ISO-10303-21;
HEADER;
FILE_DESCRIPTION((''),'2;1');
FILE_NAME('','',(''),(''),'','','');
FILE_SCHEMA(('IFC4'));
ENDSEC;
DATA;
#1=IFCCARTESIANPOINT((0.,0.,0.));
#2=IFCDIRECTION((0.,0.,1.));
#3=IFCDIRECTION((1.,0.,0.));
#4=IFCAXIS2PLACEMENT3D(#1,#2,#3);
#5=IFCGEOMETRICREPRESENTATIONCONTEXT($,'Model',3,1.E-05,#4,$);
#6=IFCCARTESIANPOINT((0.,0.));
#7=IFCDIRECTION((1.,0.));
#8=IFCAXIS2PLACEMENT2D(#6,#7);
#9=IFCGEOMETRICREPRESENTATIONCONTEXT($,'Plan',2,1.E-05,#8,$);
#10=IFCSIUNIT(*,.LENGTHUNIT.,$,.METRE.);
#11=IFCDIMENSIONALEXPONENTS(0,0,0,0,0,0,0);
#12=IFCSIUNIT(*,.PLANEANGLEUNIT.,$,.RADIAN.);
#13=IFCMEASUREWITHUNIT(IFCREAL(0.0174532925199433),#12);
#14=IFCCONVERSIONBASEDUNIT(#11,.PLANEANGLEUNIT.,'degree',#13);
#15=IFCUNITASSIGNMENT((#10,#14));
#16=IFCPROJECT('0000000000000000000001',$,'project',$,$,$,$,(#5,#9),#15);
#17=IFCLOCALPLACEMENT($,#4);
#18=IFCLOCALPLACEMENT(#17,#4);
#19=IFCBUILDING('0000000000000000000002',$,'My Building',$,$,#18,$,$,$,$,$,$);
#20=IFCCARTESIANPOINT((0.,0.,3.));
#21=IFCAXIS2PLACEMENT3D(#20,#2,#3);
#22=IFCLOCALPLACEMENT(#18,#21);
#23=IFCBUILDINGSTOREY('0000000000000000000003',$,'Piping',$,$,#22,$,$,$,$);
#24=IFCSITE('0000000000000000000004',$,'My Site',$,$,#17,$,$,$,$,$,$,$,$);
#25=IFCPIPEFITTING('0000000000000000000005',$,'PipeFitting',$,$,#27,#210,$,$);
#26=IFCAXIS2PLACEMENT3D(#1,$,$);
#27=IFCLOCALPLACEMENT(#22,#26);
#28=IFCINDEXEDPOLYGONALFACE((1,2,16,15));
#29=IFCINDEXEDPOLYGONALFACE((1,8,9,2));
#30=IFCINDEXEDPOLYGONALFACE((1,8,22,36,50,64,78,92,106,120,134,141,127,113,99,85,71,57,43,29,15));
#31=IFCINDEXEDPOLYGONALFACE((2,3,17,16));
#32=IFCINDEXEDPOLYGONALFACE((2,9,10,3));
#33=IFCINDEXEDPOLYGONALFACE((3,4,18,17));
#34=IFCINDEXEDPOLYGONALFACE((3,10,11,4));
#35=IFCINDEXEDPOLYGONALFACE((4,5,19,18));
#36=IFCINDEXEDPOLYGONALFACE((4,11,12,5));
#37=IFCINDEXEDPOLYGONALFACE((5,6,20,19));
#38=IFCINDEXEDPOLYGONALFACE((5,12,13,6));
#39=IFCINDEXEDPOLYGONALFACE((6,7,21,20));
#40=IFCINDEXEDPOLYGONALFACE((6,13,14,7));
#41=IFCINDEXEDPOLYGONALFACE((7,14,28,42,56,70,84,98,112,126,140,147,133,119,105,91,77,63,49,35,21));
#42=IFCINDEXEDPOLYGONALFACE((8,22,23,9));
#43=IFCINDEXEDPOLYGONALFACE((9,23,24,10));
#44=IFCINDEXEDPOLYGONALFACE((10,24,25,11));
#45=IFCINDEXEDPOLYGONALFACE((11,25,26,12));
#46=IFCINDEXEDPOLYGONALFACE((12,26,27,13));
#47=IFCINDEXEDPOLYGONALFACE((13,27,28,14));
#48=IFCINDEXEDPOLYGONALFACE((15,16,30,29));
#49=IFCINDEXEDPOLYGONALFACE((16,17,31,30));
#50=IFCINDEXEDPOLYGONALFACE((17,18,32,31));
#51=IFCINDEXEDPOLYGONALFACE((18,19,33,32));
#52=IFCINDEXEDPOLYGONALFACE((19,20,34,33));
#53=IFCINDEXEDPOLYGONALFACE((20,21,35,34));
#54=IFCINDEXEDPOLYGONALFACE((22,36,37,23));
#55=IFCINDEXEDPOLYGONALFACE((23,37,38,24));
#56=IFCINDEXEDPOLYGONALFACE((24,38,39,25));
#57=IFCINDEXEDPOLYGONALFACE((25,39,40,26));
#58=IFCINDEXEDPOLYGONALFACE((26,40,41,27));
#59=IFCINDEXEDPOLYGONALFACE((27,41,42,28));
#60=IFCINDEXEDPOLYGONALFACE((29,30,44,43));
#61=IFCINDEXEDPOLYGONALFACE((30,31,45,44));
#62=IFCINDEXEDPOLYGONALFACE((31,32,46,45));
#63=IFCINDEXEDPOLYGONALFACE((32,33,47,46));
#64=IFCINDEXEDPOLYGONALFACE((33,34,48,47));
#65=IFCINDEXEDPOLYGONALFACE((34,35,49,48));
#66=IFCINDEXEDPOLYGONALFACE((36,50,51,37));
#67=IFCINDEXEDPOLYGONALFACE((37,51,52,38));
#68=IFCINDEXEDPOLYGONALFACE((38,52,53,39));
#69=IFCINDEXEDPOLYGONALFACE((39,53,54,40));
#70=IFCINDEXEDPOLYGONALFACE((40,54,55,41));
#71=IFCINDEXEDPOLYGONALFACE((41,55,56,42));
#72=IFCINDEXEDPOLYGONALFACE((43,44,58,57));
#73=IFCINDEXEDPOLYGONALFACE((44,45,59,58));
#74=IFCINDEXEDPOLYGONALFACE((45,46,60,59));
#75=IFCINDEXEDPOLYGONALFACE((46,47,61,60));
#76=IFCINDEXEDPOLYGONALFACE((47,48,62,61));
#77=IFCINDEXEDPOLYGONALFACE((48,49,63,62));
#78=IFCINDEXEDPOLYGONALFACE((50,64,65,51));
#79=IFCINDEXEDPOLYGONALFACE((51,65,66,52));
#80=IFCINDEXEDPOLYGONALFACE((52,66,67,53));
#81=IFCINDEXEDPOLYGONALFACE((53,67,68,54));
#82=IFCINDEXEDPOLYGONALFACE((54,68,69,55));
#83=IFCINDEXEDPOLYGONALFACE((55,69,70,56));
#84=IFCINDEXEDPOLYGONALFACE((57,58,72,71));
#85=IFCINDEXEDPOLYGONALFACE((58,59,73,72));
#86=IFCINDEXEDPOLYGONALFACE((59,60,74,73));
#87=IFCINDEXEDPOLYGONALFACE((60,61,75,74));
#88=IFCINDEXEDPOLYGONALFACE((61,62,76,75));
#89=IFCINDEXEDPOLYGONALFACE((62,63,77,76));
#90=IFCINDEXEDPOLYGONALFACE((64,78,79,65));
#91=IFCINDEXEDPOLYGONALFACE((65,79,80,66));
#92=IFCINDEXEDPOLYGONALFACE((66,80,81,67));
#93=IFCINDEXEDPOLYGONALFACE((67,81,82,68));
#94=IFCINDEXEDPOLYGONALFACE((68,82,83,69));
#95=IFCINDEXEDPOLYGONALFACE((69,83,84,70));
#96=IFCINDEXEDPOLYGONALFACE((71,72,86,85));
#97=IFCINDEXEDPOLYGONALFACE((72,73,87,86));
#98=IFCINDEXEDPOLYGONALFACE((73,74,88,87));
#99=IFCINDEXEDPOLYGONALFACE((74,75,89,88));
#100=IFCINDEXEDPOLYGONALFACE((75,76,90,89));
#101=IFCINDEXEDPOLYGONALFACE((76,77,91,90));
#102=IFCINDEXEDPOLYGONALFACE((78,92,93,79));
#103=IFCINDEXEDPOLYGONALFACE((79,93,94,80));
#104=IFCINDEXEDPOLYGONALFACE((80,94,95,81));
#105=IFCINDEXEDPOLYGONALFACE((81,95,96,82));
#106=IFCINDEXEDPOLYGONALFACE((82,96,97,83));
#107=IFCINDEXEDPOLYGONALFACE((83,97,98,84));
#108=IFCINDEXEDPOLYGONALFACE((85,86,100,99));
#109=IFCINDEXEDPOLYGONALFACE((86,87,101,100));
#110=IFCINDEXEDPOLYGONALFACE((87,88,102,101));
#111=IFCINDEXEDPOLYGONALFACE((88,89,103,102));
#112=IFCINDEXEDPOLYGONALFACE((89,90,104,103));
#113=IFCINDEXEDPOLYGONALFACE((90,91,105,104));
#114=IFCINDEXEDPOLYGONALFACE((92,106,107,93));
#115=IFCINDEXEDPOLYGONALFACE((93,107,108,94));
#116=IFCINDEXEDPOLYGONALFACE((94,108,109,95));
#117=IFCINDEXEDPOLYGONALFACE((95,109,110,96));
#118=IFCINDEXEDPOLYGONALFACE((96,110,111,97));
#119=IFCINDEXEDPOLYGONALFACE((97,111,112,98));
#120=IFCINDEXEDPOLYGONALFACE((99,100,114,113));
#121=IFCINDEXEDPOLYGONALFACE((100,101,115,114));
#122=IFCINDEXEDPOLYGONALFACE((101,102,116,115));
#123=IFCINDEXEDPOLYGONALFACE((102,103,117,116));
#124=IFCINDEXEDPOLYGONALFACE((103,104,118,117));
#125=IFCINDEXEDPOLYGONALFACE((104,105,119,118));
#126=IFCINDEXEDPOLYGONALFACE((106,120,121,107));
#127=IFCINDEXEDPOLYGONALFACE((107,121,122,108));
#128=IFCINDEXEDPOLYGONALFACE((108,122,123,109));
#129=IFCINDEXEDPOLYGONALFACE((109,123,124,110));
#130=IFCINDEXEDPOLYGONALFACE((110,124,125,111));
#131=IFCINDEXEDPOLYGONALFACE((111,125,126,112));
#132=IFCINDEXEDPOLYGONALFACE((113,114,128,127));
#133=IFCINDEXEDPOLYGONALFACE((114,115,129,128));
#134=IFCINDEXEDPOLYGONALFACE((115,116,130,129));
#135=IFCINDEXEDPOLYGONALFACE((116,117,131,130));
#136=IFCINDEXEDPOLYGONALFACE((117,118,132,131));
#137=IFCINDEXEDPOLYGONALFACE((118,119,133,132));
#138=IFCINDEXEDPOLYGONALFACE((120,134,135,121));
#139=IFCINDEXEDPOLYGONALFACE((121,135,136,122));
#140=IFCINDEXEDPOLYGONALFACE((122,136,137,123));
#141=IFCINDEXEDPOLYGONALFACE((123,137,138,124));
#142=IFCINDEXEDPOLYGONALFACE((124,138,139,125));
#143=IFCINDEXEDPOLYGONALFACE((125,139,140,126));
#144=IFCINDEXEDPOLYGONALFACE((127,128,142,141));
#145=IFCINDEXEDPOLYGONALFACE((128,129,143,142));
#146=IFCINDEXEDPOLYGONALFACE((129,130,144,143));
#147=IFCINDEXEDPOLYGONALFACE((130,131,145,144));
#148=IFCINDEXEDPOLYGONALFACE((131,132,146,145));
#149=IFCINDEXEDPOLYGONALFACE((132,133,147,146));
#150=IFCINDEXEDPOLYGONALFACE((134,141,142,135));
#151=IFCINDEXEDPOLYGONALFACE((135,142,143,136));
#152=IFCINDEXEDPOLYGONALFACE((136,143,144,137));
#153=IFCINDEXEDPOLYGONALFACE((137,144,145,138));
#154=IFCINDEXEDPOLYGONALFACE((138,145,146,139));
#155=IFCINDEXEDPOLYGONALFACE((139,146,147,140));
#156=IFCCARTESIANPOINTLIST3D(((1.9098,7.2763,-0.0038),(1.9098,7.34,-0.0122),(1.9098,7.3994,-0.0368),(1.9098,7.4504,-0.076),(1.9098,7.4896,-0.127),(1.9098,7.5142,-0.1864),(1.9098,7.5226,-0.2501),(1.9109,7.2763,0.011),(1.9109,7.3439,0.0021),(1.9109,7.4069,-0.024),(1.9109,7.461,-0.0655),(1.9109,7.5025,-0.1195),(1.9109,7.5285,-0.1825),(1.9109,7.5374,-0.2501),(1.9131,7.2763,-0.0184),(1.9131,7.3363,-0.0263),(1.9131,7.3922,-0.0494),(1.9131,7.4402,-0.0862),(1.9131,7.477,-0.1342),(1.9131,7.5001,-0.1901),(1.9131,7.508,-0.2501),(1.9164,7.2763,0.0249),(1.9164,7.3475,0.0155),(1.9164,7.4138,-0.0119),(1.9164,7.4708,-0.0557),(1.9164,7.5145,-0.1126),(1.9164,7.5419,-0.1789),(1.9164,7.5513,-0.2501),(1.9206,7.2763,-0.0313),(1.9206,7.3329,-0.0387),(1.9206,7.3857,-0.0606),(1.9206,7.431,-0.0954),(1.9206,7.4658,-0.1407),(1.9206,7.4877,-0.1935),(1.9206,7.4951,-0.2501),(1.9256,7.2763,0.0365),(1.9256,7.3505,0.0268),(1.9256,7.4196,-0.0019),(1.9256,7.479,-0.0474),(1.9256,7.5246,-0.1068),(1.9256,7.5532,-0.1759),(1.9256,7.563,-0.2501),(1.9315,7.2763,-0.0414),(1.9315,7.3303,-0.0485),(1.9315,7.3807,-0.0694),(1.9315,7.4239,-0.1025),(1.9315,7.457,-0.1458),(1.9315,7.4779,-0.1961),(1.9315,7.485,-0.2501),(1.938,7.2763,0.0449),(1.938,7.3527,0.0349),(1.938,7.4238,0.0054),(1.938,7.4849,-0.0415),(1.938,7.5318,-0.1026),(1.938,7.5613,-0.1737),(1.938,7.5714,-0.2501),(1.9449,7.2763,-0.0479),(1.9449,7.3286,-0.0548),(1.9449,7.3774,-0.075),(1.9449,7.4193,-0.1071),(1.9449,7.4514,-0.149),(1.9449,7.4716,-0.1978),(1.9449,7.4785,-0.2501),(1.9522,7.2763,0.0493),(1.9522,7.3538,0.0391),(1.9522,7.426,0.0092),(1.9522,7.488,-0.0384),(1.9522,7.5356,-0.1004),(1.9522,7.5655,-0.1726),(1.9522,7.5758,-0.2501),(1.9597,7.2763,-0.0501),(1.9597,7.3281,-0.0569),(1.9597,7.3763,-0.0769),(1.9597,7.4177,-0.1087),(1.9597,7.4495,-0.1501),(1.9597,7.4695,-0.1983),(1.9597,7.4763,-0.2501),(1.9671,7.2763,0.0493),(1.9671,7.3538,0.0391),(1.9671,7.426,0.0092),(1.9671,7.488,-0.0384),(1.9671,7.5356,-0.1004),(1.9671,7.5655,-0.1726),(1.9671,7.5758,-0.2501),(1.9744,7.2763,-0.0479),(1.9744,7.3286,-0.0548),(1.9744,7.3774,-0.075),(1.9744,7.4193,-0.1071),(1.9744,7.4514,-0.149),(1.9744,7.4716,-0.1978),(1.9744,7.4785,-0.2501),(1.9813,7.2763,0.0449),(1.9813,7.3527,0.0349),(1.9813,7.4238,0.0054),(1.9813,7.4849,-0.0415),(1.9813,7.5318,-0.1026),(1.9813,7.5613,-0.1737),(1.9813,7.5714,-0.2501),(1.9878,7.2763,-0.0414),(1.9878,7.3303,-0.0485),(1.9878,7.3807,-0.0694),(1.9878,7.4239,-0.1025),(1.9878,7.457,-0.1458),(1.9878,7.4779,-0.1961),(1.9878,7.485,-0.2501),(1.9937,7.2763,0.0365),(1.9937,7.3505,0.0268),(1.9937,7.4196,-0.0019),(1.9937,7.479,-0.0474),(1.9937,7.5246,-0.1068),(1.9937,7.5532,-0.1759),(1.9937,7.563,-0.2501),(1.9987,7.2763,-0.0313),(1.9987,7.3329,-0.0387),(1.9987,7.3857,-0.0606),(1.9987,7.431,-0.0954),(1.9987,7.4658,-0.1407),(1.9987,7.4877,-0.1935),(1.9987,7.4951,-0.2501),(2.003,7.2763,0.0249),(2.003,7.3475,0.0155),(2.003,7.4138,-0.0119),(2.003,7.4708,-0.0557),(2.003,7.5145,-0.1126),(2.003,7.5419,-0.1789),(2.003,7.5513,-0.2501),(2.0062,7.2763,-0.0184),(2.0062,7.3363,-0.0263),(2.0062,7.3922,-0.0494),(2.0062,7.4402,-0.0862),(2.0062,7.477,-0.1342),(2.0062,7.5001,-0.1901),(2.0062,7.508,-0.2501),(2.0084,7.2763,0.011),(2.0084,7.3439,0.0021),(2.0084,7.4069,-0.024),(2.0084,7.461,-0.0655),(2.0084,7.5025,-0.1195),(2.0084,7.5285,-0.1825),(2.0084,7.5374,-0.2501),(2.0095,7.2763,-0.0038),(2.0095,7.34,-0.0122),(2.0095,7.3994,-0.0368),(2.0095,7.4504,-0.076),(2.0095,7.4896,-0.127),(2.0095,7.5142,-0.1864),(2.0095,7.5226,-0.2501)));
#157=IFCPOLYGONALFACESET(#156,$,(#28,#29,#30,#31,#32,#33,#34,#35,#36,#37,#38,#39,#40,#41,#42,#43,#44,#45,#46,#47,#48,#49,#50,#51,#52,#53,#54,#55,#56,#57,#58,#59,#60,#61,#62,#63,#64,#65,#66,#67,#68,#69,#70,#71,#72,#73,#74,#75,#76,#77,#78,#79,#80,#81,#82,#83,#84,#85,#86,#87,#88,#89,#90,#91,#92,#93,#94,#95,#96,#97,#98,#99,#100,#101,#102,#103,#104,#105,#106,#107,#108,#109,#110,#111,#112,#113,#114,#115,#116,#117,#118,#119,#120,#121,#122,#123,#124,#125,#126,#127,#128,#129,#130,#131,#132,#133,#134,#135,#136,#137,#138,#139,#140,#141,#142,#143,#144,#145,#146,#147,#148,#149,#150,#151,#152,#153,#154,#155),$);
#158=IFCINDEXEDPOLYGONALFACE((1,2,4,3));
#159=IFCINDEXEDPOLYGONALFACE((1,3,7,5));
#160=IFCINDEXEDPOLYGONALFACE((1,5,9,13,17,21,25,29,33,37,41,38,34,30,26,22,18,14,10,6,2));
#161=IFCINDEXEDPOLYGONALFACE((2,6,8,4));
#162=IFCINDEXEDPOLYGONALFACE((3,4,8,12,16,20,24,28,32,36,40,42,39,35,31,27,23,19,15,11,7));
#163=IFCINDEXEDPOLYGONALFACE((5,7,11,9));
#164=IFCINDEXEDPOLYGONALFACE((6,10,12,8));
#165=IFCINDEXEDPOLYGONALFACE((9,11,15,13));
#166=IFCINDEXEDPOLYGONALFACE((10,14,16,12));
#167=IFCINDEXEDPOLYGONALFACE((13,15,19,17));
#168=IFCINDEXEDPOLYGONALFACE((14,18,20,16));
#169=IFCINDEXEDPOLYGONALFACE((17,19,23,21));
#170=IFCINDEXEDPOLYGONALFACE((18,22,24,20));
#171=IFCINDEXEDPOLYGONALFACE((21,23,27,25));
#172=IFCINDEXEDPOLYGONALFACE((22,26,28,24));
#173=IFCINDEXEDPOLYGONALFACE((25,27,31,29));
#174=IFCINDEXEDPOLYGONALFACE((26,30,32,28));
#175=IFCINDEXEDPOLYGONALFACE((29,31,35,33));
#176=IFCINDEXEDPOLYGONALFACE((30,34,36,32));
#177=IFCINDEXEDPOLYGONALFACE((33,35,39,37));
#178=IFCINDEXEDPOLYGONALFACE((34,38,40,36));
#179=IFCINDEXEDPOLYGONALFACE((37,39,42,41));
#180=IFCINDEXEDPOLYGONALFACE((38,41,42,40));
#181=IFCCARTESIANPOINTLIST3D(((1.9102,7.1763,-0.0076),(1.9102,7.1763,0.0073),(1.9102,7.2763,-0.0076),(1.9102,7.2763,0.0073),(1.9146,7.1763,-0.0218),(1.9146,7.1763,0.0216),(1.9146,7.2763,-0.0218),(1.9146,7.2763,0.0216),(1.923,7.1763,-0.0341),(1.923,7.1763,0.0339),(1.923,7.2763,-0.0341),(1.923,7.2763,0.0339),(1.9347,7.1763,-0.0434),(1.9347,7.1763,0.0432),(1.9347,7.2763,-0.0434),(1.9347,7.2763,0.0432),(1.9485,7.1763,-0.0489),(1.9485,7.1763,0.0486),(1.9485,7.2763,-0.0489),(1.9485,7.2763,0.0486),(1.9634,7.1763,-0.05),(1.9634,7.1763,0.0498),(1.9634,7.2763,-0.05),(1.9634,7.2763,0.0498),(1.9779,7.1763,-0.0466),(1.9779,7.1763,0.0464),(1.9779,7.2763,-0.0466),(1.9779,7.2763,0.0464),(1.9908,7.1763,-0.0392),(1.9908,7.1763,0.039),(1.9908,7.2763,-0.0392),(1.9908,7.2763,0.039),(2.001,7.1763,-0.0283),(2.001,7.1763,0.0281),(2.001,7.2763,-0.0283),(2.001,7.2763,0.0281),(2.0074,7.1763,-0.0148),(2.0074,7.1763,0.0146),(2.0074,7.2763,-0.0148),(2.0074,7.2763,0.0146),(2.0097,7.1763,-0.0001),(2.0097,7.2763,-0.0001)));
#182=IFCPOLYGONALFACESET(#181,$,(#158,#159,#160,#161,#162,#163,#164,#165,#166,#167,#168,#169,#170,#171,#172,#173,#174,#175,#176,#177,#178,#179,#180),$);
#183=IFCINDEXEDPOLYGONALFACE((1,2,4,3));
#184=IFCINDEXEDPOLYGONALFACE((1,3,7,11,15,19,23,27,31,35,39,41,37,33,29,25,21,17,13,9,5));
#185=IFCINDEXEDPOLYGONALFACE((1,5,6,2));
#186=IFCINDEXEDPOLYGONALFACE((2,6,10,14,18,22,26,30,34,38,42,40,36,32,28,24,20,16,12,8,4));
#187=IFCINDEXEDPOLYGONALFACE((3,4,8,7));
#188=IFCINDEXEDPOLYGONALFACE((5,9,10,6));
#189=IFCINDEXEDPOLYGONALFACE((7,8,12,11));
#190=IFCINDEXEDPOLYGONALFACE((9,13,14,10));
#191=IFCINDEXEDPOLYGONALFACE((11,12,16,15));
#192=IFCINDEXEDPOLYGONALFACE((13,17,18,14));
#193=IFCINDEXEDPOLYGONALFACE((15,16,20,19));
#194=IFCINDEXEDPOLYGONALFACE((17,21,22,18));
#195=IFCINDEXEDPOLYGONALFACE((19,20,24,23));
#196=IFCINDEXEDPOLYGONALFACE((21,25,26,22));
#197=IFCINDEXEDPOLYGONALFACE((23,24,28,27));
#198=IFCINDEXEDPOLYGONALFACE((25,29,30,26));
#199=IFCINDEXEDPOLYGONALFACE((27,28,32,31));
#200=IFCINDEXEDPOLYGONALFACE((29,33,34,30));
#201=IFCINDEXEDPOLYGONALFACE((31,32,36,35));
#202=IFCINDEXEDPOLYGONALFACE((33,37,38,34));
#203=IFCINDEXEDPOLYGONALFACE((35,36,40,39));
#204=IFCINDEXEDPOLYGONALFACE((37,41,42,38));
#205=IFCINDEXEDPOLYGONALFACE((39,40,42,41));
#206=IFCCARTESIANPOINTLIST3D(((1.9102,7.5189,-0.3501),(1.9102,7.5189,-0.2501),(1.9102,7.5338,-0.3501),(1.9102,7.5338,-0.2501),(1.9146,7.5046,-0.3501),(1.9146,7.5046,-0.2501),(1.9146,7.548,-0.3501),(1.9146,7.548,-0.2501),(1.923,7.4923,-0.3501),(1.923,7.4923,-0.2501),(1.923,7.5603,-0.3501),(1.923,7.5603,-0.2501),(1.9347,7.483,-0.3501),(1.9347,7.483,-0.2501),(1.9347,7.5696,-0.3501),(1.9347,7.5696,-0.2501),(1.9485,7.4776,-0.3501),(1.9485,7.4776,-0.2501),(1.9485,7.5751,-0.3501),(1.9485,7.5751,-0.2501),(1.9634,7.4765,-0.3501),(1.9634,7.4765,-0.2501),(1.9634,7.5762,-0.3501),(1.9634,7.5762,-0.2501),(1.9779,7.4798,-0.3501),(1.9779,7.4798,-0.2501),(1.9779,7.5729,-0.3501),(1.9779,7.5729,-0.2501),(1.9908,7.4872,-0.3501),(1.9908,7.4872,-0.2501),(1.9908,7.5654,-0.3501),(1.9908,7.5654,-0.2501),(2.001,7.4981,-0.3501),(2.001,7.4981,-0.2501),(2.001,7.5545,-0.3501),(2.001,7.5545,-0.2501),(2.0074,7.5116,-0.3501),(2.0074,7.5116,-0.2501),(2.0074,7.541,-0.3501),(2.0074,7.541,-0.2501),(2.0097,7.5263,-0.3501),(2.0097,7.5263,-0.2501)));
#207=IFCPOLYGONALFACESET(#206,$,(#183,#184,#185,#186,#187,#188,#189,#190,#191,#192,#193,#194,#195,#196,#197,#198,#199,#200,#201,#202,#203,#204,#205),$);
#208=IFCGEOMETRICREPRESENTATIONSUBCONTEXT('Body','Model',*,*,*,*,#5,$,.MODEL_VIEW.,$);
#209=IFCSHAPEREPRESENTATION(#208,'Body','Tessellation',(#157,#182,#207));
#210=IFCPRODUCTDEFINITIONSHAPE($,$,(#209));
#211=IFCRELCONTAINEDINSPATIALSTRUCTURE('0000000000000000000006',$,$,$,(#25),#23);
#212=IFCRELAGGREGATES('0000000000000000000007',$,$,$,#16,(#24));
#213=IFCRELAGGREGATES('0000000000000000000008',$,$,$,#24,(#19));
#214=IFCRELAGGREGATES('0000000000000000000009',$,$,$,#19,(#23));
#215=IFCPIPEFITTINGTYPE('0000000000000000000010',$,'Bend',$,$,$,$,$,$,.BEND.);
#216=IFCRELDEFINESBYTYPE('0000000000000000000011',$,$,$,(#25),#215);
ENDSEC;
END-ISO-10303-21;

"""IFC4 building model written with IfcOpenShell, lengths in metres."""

from ifc_helpers import new_model, entity, si_unit, converted_unit, frame, origin_with_axes, origin_2d_with_axis, place, context, subcontext, project, spatial, circle, extrude, source, transform, mapped, type_object, type_shapes, element, save


model = new_model("IFC4")

# Units and contexts
model_context = context("Model", 3, precision=1e-05, world=origin_with_axes())
plan_context = context("Plan", 2, precision=1e-05, world=origin_2d_with_axis())
body_context = subcontext(model_context, "Body", "Model", "MODEL_VIEW")
ifc_project = project(units=[si_unit("LENGTHUNIT", "METRE"), converted_unit("PLANEANGLEUNIT", "degree", entity("IfcReal", 0.0174532925199433), si_unit("PLANEANGLEUNIT", "RADIAN"), dimensions=[0, 0, 0, 0, 0, 0, 0])], contexts=[model_context, plan_context])

# Site, building, storey
site_placement = place(None, origin_with_axes())
site = spatial("IfcSite", under=ifc_project, at=site_placement, Name="My Site")
building_placement = place(site_placement, origin_with_axes())
building = spatial("IfcBuilding", under=site, at=building_placement, Name="My Building")
storey_placement = place(building_placement, frame((0.0, 0.0, 3.0), z_axis=(0.0, 0.0, 1.0), x_axis=(1.0, 0.0, 0.0)))
storey = spatial("IfcBuildingStorey", under=building, at=storey_placement, Name="Piping")

# Pipe fitting
pipe_fitting_type = type_object("IfcPipeFittingType", Name="Bend", PredefinedType="BEND")
shared_shape = source(origin_with_axes(), body_context, "Body", "SolidModel", [
    entity("IfcSweptDiskSolid", entity("IfcIndexedPolyCurve", entity("IfcCartesianPointList3D", [[0.0, 0.0, -0.1], [0.0, -0.0732, -0.2768], [0.0, -0.25, -0.35]]), [entity("IfcArcIndex", [1, 2, 3])]), 0.05),
    extrude(circle(Radius=0.05), origin_with_axes(), (0.0, 0.0, -1.0), 0.1),
    extrude(circle(Radius=0.05), frame((0.0, -0.25, -0.35), z_axis=(0.0, -1.0, 0.0), x_axis=(1.0, 0.0, 0.0)), (0.0, 0.0, 1.0), 0.1),
])
type_shapes(pipe_fitting_type, [shared_shape])
for number, where, z_axis, x_axis, name in (
    (1, (1.9597, 7.1763, -0.0001), (0.0, -1.0, 0.0), (1.0, 0.0, 0.0), "PipeFitting"),
):
    element("IfcPipeFitting", number, at=place(storey_placement, frame(where, z_axis=z_axis, x_axis=x_axis)), inside=storey, type_object=pipe_fitting_type, Name=name, context=body_context, shape_type="MappedRepresentation", body=[
        mapped(shared_shape, transform((0.0, 0.0, 0.0), x_axis=(1.0, 0.0, 0.0), y_axis=(0.0, 1.0, 0.0), z_axis=(0.0, 0.0, 1.0), scale=1.0)),
    ])

save(model, "model.ifc")
